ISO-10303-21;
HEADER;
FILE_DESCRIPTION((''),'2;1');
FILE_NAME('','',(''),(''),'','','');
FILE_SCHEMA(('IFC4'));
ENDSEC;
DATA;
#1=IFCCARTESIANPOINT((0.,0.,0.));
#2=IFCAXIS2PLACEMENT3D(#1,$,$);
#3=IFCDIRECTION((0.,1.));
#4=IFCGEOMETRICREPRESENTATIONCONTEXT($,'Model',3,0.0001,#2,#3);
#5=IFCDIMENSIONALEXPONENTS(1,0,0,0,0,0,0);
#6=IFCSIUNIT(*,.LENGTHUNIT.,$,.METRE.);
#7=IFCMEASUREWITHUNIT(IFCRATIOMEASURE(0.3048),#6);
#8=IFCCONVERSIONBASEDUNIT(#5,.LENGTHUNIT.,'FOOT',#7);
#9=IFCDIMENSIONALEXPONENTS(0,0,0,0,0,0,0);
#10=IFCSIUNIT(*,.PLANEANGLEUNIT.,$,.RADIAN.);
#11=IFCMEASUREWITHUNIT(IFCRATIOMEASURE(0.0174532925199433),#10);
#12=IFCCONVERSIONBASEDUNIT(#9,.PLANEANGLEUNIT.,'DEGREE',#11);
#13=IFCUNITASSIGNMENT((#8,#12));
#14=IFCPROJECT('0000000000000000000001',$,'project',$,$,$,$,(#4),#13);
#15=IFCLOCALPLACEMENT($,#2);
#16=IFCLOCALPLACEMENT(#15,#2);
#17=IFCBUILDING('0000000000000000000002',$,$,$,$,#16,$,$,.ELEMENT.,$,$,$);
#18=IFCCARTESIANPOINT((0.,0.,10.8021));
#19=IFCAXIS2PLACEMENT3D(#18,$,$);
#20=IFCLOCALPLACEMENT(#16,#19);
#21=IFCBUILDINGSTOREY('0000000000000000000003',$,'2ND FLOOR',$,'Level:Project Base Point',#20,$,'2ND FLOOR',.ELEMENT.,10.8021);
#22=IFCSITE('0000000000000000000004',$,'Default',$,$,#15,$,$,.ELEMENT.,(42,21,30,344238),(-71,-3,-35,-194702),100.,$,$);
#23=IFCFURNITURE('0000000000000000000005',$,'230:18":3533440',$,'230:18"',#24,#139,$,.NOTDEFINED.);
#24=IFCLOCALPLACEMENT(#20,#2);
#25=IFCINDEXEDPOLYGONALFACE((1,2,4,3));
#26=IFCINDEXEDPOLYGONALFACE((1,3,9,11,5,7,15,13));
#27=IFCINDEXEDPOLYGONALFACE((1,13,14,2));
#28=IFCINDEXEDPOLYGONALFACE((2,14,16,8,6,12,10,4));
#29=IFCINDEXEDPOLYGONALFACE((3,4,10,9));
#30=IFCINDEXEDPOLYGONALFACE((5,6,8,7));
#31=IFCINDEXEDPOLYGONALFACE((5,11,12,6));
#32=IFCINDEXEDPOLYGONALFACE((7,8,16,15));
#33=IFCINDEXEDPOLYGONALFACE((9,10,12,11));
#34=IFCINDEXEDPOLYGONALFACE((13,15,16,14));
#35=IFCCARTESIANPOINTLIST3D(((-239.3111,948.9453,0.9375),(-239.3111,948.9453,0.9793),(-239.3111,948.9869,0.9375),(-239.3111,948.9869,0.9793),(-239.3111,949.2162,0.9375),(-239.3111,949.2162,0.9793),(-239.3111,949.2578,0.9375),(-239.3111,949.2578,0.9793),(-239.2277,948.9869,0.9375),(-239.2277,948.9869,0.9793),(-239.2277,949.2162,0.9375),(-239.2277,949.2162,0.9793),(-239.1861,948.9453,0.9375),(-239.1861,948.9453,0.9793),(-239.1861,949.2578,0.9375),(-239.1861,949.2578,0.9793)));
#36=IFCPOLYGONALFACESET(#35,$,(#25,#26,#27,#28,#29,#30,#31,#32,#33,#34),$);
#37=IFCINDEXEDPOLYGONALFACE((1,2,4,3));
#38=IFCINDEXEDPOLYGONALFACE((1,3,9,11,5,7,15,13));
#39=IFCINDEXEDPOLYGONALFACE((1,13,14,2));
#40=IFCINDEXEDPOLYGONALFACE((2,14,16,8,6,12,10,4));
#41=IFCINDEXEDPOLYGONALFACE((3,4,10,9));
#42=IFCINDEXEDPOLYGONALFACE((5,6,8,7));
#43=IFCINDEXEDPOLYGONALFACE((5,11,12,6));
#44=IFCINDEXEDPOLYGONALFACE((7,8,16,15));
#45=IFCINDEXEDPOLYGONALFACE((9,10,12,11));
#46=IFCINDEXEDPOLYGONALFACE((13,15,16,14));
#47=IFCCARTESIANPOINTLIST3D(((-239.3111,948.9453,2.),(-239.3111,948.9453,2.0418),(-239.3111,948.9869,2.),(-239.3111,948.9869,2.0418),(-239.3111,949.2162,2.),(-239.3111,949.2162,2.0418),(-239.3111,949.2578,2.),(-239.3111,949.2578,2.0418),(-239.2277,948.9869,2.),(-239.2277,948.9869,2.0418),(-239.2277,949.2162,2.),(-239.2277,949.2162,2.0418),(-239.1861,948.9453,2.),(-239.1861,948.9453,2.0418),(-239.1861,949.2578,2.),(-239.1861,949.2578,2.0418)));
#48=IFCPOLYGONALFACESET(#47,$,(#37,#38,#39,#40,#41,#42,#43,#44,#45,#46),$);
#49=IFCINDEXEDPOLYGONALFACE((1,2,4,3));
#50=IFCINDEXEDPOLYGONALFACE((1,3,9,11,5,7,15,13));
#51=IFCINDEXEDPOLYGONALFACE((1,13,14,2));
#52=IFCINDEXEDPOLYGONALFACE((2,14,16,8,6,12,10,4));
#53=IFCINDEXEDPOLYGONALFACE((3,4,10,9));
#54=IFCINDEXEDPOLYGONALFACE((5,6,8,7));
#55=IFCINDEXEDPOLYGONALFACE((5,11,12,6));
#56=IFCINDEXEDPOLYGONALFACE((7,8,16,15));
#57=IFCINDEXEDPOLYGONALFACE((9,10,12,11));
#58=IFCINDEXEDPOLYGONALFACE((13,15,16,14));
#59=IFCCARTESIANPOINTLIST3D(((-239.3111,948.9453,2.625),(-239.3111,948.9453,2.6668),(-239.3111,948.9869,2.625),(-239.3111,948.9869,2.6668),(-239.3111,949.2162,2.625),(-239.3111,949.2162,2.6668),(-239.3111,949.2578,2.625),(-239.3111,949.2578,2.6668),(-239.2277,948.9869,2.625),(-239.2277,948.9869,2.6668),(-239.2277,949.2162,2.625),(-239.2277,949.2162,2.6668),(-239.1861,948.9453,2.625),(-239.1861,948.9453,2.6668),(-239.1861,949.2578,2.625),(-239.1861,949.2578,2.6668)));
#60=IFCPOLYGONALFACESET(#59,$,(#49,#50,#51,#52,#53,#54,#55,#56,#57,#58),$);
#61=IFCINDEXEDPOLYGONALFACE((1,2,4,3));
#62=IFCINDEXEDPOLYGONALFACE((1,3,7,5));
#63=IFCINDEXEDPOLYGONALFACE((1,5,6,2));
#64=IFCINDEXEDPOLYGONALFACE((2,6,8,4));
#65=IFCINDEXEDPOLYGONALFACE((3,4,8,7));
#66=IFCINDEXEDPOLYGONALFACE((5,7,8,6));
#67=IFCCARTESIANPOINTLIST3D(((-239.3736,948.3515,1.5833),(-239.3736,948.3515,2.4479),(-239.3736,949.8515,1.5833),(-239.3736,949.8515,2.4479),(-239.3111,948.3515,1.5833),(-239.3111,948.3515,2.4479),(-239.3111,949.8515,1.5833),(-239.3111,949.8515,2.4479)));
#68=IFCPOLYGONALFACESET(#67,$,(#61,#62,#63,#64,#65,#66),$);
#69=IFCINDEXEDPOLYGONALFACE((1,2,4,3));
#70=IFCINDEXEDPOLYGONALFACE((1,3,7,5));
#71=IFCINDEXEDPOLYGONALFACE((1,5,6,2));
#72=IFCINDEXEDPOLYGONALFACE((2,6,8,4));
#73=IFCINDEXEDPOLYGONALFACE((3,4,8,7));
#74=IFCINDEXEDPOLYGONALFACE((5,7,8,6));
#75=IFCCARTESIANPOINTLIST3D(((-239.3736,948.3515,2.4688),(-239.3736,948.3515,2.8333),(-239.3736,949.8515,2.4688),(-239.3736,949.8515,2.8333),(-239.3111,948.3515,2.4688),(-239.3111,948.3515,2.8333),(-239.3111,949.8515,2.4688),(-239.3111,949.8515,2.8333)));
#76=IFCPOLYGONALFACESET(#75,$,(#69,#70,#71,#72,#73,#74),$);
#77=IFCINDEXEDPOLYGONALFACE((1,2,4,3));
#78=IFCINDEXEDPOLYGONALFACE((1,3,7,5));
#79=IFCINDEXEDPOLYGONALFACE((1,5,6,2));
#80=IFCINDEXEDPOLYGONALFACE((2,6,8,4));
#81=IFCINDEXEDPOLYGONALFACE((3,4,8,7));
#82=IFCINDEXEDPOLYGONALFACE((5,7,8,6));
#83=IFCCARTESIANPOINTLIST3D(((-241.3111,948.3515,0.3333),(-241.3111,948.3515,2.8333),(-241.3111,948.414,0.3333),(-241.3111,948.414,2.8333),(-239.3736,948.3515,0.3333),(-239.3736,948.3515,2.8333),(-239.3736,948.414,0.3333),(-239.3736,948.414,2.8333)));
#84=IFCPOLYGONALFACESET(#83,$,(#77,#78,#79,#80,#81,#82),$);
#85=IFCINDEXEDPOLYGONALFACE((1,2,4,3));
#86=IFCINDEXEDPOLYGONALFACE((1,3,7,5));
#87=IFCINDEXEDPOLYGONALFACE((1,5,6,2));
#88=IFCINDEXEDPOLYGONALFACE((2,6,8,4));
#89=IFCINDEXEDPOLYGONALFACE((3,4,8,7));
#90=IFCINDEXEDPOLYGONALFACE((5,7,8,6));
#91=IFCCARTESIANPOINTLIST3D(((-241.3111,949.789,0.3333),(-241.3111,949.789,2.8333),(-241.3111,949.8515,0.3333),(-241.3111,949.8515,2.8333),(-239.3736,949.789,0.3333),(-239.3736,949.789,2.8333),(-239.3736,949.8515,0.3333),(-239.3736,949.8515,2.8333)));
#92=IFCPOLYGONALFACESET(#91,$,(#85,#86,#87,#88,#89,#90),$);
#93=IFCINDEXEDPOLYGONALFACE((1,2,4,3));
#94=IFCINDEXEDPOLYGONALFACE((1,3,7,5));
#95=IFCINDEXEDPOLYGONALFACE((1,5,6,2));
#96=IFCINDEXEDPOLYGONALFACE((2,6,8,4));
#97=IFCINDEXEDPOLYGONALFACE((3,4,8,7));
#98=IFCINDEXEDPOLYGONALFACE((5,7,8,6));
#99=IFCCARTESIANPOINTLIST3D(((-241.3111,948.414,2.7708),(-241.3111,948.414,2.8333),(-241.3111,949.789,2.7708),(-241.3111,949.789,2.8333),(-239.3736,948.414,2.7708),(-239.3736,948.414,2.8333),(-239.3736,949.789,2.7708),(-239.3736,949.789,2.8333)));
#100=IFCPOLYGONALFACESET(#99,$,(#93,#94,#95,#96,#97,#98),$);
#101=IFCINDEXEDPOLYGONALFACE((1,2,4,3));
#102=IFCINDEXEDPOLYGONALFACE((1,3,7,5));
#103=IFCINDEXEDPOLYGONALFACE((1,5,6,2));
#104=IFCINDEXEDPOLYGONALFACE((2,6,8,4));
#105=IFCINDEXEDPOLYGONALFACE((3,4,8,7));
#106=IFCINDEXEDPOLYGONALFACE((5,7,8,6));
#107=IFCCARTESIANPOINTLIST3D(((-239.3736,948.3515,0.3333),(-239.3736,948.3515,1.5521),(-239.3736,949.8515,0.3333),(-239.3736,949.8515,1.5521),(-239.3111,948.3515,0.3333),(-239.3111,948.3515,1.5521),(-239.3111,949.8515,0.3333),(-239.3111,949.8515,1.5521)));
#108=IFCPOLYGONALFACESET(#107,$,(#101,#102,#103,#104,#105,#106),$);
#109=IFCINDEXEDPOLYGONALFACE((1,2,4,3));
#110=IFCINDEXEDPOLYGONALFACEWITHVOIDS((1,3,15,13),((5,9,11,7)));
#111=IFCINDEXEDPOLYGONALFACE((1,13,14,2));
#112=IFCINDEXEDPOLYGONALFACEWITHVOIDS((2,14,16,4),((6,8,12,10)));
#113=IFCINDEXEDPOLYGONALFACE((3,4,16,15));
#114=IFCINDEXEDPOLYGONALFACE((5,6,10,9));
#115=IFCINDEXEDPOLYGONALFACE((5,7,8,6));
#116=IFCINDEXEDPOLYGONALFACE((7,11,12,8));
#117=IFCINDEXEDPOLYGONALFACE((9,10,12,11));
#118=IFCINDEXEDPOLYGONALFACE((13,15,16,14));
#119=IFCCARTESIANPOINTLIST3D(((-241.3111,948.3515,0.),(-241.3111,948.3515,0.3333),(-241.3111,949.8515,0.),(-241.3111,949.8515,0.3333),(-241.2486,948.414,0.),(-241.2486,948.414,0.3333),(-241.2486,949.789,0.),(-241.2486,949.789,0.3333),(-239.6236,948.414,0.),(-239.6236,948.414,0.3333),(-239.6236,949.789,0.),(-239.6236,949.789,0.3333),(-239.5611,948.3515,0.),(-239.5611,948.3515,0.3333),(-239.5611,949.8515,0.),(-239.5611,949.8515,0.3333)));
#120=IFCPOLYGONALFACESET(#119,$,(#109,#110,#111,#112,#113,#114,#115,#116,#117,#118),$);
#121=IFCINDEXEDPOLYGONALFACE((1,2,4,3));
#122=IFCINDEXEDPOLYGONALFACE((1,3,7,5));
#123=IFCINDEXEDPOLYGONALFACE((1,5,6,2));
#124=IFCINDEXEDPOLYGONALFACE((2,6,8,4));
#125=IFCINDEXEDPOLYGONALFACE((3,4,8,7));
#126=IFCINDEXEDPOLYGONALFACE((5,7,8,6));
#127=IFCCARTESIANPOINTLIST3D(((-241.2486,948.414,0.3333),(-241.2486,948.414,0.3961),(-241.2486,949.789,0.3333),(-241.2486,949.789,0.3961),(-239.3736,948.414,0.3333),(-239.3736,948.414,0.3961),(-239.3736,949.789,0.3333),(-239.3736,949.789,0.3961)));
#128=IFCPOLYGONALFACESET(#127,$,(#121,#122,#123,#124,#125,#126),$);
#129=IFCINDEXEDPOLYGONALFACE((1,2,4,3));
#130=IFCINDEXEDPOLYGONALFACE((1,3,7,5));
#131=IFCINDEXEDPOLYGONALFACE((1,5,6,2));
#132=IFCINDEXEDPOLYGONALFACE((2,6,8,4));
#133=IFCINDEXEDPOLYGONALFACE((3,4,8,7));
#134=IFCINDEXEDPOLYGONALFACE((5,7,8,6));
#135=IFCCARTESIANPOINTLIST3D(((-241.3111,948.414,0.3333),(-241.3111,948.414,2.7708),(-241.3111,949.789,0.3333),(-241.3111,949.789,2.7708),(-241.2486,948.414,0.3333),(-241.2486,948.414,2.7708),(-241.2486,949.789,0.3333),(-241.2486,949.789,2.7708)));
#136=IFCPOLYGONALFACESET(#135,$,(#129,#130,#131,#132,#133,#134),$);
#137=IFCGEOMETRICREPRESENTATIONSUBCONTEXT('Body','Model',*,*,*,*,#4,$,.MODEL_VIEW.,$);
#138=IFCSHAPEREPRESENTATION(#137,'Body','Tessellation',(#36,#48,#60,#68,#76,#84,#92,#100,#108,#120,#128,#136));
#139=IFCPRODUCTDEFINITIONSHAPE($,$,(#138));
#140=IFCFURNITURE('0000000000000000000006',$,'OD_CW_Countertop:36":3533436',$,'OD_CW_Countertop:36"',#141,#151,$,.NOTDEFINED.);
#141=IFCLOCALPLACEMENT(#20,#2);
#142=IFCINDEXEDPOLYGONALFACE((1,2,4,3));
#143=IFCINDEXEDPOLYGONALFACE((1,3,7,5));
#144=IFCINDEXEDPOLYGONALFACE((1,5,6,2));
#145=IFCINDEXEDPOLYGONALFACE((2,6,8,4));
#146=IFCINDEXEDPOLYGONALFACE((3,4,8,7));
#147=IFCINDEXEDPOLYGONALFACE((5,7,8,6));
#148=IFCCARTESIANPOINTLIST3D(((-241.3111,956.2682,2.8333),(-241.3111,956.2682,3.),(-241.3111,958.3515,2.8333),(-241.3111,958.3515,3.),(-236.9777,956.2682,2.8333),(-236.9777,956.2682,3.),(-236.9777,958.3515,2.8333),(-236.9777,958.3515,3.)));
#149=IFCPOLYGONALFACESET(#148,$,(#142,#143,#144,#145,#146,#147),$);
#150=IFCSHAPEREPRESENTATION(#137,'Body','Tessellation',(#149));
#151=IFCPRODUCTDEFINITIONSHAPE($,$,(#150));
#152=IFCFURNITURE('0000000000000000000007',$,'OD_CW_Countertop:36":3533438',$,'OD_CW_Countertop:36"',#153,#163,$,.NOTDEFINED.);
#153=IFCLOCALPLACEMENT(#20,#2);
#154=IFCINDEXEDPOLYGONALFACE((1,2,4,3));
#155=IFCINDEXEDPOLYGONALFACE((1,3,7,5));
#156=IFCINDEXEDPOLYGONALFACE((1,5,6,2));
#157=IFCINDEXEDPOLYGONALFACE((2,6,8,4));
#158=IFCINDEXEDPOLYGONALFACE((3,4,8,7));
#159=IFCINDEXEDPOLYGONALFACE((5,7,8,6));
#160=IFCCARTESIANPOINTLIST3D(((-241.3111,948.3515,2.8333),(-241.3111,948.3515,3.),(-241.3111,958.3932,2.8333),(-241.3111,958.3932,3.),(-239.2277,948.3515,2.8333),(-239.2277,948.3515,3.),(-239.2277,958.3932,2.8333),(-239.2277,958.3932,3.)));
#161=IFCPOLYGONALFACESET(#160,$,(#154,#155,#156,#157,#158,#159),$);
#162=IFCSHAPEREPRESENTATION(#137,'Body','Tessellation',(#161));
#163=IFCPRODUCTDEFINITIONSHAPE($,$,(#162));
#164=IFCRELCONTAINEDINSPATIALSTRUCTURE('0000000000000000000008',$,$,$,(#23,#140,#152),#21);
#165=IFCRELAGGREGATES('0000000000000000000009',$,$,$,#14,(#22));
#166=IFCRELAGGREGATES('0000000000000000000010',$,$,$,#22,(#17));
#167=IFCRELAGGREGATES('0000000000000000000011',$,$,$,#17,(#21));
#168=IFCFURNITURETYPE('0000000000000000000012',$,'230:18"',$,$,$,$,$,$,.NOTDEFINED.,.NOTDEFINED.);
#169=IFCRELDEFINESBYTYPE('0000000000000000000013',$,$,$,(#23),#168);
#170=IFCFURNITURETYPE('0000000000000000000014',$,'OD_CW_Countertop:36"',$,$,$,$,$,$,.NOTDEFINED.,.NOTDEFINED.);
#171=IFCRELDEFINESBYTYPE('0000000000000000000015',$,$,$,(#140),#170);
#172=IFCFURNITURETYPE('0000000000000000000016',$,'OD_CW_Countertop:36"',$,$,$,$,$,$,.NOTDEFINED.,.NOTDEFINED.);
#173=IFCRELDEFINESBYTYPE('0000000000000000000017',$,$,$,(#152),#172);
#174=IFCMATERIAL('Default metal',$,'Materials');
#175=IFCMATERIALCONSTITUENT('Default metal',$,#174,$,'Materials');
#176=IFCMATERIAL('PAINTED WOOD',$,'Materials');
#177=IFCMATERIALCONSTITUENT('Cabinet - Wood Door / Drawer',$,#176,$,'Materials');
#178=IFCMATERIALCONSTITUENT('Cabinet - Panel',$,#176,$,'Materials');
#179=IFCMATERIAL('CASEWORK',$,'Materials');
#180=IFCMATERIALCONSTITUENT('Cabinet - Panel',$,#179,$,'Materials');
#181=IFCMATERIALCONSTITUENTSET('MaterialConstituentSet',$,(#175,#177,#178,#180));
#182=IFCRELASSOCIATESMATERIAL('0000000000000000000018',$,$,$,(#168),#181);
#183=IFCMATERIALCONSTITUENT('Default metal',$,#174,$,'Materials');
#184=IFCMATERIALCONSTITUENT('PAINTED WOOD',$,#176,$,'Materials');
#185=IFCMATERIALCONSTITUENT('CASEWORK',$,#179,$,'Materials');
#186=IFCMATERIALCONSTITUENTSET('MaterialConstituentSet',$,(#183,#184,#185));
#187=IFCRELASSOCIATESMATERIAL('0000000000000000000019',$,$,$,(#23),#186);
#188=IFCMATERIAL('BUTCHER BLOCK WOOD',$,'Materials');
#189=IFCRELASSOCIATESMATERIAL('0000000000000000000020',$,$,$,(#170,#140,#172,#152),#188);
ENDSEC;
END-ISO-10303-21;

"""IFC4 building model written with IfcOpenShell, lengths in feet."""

from ifc_helpers import new_model, entity, si_unit, converted_unit, direction, frame, frame_2d, origin, origin_2d_with_axis, place, context, subcontext, project, spatial, polyline, rectangle, outline, extrude, source, transform, mapped, material, constituent, constituent_set, type_object, type_shapes, element, save


model = new_model("IFC4")

# Units and contexts
model_context = context("Model", 3, precision=0.0001, world=origin(), true_north=direction((0.0, 1.0)))
body_context = subcontext(model_context, "Body", "Model", "MODEL_VIEW")
ifc_project = project(units=[converted_unit("LENGTHUNIT", "FOOT", entity("IfcRatioMeasure", 0.3048), si_unit("LENGTHUNIT", "METRE"), dimensions=[1, 0, 0, 0, 0, 0, 0]), converted_unit("PLANEANGLEUNIT", "DEGREE", entity("IfcRatioMeasure", 0.0174532925199433), si_unit("PLANEANGLEUNIT", "RADIAN"), dimensions=[0, 0, 0, 0, 0, 0, 0])], contexts=[model_context])

# Site, building, storey
site_placement = place(None, origin())
site = spatial("IfcSite", under=ifc_project, at=site_placement, Name="Default", CompositionType="ELEMENT", RefLatitude=(42, 21, 30, 344238), RefLongitude=(-71, -3, -35, -194702), RefElevation=100.0)
building_placement = place(site_placement, origin())
building = spatial("IfcBuilding", under=site, at=building_placement, CompositionType="ELEMENT")
storey_placement = place(building_placement, frame((0.0, 0.0, 10.8021)))
storey = spatial("IfcBuildingStorey", under=building, at=storey_placement, Name="2ND FLOOR", ObjectType="Level:Project Base Point", LongName="2ND FLOOR", CompositionType="ELEMENT", Elevation=10.8021)

# Shared definitions
ifc_material_1 = material(Name="Default metal", Category="Materials")
ifc_material_2 = material(Name="PAINTED WOOD", Category="Materials")
ifc_material_3 = material(Name="CASEWORK", Category="Materials")

# Furniture
ifc_material_4 = material(Name="BUTCHER BLOCK WOOD", Category="Materials")
ifc_constituent_1 = constituent(ifc_material_1, Name="Default metal", Category="Materials")
ifc_constituent_2 = constituent(ifc_material_2, Name="PAINTED WOOD", Category="Materials")
ifc_constituent_3 = constituent(ifc_material_3, Name="CASEWORK", Category="Materials")
ifc_constituent_set_1 = constituent_set(constituents=[ifc_constituent_1, ifc_constituent_2, ifc_constituent_3], Name="MaterialConstituentSet")
ifc_constituent_4 = constituent(ifc_material_1, Name="Default metal", Category="Materials")
ifc_constituent_5 = constituent(ifc_material_2, Name="Cabinet - Wood Door / Drawer", Category="Materials")
ifc_constituent_6 = constituent(ifc_material_2, Name="Cabinet - Panel", Category="Materials")
ifc_constituent_7 = constituent(ifc_material_3, Name="Cabinet - Panel", Category="Materials")
ifc_constituent_set_2 = constituent_set(constituents=[ifc_constituent_4, ifc_constituent_5, ifc_constituent_6, ifc_constituent_7], Name="MaterialConstituentSet")
furniture_type_1 = type_object("IfcFurnitureType", Name="230:18\"", AssemblyPlace="NOTDEFINED", PredefinedType="NOTDEFINED", material=ifc_constituent_set_2)
shared_shape_1 = source(origin(), body_context, "Body", "SweptSolid", [
    extrude(outline(polyline([(-0.0521, -0.1562), (0.0729, -0.1562), (0.0729, 0.1562), (-0.0521, 0.1562), (-0.0521, 0.1146), (0.0313, 0.1146), (0.0313, -0.1146), (-0.0521, -0.1146), (-0.0521, -0.1562)])), frame((0.0615, -2.0521, 0.9375), z_axis=(0.0, 0.0, 1.0), x_axis=(0.0, -1.0, 0.0)), (0.0, 0.0, 1.0), 0.0418),
    extrude(outline(polyline([(-0.0521, -0.1562), (0.0729, -0.1562), (0.0729, 0.1562), (-0.0521, 0.1562), (-0.0521, 0.1146), (0.0313, 0.1146), (0.0313, -0.1146), (-0.0521, -0.1146), (-0.0521, -0.1562)])), frame((0.0615, -2.0521, 2.0), z_axis=(0.0, 0.0, 1.0), x_axis=(0.0, -1.0, 0.0)), (0.0, 0.0, 1.0), 0.0418),
    extrude(outline(polyline([(-0.0521, -0.1562), (0.0729, -0.1562), (0.0729, 0.1562), (-0.0521, 0.1562), (-0.0521, 0.1146), (0.0313, 0.1146), (0.0313, -0.1146), (-0.0521, -0.1146), (-0.0521, -0.1562)])), frame((0.0615, -2.0521, 2.625), z_axis=(0.0, 0.0, 1.0), x_axis=(0.0, -1.0, 0.0)), (0.0, 0.0, 1.0), 0.0418),
    extrude(rectangle(XDim=0.0625, YDim=1.5, at=frame_2d((0.0, 0.0), x_axis=(1.0, 0.0))), frame((0.0615, -1.9688, 1.5833), z_axis=(0.0, 0.0, 1.0), x_axis=(0.0, 1.0, 0.0)), (0.0, 0.0, 1.0), 0.8646),
    extrude(rectangle(XDim=0.0625, YDim=1.5, at=frame_2d((0.0, 0.0), x_axis=(1.0, 0.0))), frame((0.0615, -1.9688, 2.4688), z_axis=(0.0, 0.0, 1.0), x_axis=(0.0, 1.0, 0.0)), (0.0, 0.0, 1.0), 0.3646),
    extrude(rectangle(XDim=0.0625, YDim=1.9375, at=frame_2d((0.0, 0.0), x_axis=(1.0, 0.0))), frame((-0.6573, -0.9687, 0.3333)), (0.0, 0.0, 1.0), 2.5),
    extrude(rectangle(XDim=0.0625, YDim=1.9375, at=frame_2d((0.0, 0.0), x_axis=(1.0, 0.0))), frame((0.7802, -0.9687, 0.3333)), (0.0, 0.0, 1.0), 2.5),
    extrude(rectangle(XDim=1.375, YDim=1.9375, at=origin_2d_with_axis()), frame((0.0615, -0.9687, 2.7708), z_axis=(0.0, 0.0, 1.0), x_axis=(-1.0, 0.0, 0.0)), (0.0, 0.0, 1.0), 0.0625),
    extrude(rectangle(XDim=0.0625, YDim=1.5, at=frame_2d((0.0, 0.0), x_axis=(1.0, 0.0))), frame((0.0615, -1.9688, 0.3333), z_axis=(0.0, 0.0, 1.0), x_axis=(0.0, 1.0, 0.0)), (0.0, 0.0, 1.0), 1.2187),
    extrude(outline(polyline([(-0.75, -0.875), (0.75, -0.875), (0.75, 0.875), (-0.75, 0.875), (-0.75, -0.875)]), holes=[polyline([(-0.6875, -0.8125), (-0.6875, 0.8125), (0.6875, 0.8125), (0.6875, -0.8125), (-0.6875, -0.8125)])]), frame((0.0615, -0.875, 0.0)), (0.0, 0.0, 1.0), 0.3333),
    extrude(rectangle(XDim=1.375, YDim=1.875, at=frame_2d((0.0, 0.0), x_axis=(1.0, 0.0))), frame((0.0615, -1.0, 0.3333), z_axis=(0.0, 0.0, 1.0), x_axis=(-1.0, 0.0, 0.0)), (0.0, 0.0, 1.0), 0.0627),
    extrude(rectangle(XDim=0.0625, YDim=1.375, at=origin_2d_with_axis()), frame((0.0615, -0.0312, 0.3333), z_axis=(0.0, 0.0, 1.0), x_axis=(0.0, 1.0, 0.0)), (0.0, 0.0, 1.0), 2.4375),
])
type_shapes(furniture_type_1, [shared_shape_1])
furniture_1_placement = place(storey_placement, frame((-241.3111, 949.04, 0.0), z_axis=(0.0, 0.0, 1.0), x_axis=(0.0, 1.0, 0.0)))
element("IfcFurniture", 1, at=furniture_1_placement, inside=storey, type_object=furniture_type_1, material=ifc_constituent_set_1, Name="230:18\":3533440", ObjectType="230:18\"", PredefinedType="NOTDEFINED", context=body_context, shape_type="MappedRepresentation", body=[
    mapped(shared_shape_1, transform((0.0, 0.0, 0.0), scale=1.0)),
])
furniture_type_2 = type_object("IfcFurnitureType", Name="OD_CW_Countertop:36\"", AssemblyPlace="NOTDEFINED", PredefinedType="NOTDEFINED", material=ifc_material_4)
shared_shape_2 = source(origin(), body_context, "Body", "SweptSolid", [
    extrude(rectangle(XDim=4.3333, YDim=2.0833, at=origin_2d_with_axis()), frame((2.1667, 1.0417, 0.0)), (0.0, 0.0, 1.0), 0.1667),
])
type_shapes(furniture_type_2, [shared_shape_2])
furniture_2_placement = place(storey_placement, frame((-236.9777, 958.3515, 2.8333), z_axis=(0.0, 0.0, 1.0), x_axis=(-1.0, 0.0, 0.0)))
element("IfcFurniture", 2, at=furniture_2_placement, inside=storey, type_object=furniture_type_2, material=ifc_material_4, Name="OD_CW_Countertop:36\":3533436", ObjectType="OD_CW_Countertop:36\"", PredefinedType="NOTDEFINED", context=body_context, shape_type="MappedRepresentation", body=[
    mapped(shared_shape_2, transform((0.0, 0.0, 0.0), scale=1.0)),
])
furniture_type_3 = type_object("IfcFurnitureType", Name="OD_CW_Countertop:36\"", AssemblyPlace="NOTDEFINED", PredefinedType="NOTDEFINED", material=ifc_material_4)
shared_shape_3 = source(origin(), body_context, "Body", "SweptSolid", [
    extrude(rectangle(XDim=10.0417, YDim=2.0833, at=origin_2d_with_axis()), frame((5.0208, 1.0417, 0.0)), (0.0, 0.0, 1.0), 0.1667),
])
type_shapes(furniture_type_3, [shared_shape_3])
furniture_3_placement = place(storey_placement, frame((-241.3111, 958.3932, 2.8333), z_axis=(0.0, 0.0, 1.0), x_axis=(0.0, -1.0, 0.0)))
element("IfcFurniture", 3, at=furniture_3_placement, inside=storey, type_object=furniture_type_3, material=ifc_material_4, Name="OD_CW_Countertop:36\":3533438", ObjectType="OD_CW_Countertop:36\"", PredefinedType="NOTDEFINED", context=body_context, shape_type="MappedRepresentation", body=[
    mapped(shared_shape_3, transform((0.0, 0.0, 0.0), scale=1.0)),
])

save(model, "model.ifc")
